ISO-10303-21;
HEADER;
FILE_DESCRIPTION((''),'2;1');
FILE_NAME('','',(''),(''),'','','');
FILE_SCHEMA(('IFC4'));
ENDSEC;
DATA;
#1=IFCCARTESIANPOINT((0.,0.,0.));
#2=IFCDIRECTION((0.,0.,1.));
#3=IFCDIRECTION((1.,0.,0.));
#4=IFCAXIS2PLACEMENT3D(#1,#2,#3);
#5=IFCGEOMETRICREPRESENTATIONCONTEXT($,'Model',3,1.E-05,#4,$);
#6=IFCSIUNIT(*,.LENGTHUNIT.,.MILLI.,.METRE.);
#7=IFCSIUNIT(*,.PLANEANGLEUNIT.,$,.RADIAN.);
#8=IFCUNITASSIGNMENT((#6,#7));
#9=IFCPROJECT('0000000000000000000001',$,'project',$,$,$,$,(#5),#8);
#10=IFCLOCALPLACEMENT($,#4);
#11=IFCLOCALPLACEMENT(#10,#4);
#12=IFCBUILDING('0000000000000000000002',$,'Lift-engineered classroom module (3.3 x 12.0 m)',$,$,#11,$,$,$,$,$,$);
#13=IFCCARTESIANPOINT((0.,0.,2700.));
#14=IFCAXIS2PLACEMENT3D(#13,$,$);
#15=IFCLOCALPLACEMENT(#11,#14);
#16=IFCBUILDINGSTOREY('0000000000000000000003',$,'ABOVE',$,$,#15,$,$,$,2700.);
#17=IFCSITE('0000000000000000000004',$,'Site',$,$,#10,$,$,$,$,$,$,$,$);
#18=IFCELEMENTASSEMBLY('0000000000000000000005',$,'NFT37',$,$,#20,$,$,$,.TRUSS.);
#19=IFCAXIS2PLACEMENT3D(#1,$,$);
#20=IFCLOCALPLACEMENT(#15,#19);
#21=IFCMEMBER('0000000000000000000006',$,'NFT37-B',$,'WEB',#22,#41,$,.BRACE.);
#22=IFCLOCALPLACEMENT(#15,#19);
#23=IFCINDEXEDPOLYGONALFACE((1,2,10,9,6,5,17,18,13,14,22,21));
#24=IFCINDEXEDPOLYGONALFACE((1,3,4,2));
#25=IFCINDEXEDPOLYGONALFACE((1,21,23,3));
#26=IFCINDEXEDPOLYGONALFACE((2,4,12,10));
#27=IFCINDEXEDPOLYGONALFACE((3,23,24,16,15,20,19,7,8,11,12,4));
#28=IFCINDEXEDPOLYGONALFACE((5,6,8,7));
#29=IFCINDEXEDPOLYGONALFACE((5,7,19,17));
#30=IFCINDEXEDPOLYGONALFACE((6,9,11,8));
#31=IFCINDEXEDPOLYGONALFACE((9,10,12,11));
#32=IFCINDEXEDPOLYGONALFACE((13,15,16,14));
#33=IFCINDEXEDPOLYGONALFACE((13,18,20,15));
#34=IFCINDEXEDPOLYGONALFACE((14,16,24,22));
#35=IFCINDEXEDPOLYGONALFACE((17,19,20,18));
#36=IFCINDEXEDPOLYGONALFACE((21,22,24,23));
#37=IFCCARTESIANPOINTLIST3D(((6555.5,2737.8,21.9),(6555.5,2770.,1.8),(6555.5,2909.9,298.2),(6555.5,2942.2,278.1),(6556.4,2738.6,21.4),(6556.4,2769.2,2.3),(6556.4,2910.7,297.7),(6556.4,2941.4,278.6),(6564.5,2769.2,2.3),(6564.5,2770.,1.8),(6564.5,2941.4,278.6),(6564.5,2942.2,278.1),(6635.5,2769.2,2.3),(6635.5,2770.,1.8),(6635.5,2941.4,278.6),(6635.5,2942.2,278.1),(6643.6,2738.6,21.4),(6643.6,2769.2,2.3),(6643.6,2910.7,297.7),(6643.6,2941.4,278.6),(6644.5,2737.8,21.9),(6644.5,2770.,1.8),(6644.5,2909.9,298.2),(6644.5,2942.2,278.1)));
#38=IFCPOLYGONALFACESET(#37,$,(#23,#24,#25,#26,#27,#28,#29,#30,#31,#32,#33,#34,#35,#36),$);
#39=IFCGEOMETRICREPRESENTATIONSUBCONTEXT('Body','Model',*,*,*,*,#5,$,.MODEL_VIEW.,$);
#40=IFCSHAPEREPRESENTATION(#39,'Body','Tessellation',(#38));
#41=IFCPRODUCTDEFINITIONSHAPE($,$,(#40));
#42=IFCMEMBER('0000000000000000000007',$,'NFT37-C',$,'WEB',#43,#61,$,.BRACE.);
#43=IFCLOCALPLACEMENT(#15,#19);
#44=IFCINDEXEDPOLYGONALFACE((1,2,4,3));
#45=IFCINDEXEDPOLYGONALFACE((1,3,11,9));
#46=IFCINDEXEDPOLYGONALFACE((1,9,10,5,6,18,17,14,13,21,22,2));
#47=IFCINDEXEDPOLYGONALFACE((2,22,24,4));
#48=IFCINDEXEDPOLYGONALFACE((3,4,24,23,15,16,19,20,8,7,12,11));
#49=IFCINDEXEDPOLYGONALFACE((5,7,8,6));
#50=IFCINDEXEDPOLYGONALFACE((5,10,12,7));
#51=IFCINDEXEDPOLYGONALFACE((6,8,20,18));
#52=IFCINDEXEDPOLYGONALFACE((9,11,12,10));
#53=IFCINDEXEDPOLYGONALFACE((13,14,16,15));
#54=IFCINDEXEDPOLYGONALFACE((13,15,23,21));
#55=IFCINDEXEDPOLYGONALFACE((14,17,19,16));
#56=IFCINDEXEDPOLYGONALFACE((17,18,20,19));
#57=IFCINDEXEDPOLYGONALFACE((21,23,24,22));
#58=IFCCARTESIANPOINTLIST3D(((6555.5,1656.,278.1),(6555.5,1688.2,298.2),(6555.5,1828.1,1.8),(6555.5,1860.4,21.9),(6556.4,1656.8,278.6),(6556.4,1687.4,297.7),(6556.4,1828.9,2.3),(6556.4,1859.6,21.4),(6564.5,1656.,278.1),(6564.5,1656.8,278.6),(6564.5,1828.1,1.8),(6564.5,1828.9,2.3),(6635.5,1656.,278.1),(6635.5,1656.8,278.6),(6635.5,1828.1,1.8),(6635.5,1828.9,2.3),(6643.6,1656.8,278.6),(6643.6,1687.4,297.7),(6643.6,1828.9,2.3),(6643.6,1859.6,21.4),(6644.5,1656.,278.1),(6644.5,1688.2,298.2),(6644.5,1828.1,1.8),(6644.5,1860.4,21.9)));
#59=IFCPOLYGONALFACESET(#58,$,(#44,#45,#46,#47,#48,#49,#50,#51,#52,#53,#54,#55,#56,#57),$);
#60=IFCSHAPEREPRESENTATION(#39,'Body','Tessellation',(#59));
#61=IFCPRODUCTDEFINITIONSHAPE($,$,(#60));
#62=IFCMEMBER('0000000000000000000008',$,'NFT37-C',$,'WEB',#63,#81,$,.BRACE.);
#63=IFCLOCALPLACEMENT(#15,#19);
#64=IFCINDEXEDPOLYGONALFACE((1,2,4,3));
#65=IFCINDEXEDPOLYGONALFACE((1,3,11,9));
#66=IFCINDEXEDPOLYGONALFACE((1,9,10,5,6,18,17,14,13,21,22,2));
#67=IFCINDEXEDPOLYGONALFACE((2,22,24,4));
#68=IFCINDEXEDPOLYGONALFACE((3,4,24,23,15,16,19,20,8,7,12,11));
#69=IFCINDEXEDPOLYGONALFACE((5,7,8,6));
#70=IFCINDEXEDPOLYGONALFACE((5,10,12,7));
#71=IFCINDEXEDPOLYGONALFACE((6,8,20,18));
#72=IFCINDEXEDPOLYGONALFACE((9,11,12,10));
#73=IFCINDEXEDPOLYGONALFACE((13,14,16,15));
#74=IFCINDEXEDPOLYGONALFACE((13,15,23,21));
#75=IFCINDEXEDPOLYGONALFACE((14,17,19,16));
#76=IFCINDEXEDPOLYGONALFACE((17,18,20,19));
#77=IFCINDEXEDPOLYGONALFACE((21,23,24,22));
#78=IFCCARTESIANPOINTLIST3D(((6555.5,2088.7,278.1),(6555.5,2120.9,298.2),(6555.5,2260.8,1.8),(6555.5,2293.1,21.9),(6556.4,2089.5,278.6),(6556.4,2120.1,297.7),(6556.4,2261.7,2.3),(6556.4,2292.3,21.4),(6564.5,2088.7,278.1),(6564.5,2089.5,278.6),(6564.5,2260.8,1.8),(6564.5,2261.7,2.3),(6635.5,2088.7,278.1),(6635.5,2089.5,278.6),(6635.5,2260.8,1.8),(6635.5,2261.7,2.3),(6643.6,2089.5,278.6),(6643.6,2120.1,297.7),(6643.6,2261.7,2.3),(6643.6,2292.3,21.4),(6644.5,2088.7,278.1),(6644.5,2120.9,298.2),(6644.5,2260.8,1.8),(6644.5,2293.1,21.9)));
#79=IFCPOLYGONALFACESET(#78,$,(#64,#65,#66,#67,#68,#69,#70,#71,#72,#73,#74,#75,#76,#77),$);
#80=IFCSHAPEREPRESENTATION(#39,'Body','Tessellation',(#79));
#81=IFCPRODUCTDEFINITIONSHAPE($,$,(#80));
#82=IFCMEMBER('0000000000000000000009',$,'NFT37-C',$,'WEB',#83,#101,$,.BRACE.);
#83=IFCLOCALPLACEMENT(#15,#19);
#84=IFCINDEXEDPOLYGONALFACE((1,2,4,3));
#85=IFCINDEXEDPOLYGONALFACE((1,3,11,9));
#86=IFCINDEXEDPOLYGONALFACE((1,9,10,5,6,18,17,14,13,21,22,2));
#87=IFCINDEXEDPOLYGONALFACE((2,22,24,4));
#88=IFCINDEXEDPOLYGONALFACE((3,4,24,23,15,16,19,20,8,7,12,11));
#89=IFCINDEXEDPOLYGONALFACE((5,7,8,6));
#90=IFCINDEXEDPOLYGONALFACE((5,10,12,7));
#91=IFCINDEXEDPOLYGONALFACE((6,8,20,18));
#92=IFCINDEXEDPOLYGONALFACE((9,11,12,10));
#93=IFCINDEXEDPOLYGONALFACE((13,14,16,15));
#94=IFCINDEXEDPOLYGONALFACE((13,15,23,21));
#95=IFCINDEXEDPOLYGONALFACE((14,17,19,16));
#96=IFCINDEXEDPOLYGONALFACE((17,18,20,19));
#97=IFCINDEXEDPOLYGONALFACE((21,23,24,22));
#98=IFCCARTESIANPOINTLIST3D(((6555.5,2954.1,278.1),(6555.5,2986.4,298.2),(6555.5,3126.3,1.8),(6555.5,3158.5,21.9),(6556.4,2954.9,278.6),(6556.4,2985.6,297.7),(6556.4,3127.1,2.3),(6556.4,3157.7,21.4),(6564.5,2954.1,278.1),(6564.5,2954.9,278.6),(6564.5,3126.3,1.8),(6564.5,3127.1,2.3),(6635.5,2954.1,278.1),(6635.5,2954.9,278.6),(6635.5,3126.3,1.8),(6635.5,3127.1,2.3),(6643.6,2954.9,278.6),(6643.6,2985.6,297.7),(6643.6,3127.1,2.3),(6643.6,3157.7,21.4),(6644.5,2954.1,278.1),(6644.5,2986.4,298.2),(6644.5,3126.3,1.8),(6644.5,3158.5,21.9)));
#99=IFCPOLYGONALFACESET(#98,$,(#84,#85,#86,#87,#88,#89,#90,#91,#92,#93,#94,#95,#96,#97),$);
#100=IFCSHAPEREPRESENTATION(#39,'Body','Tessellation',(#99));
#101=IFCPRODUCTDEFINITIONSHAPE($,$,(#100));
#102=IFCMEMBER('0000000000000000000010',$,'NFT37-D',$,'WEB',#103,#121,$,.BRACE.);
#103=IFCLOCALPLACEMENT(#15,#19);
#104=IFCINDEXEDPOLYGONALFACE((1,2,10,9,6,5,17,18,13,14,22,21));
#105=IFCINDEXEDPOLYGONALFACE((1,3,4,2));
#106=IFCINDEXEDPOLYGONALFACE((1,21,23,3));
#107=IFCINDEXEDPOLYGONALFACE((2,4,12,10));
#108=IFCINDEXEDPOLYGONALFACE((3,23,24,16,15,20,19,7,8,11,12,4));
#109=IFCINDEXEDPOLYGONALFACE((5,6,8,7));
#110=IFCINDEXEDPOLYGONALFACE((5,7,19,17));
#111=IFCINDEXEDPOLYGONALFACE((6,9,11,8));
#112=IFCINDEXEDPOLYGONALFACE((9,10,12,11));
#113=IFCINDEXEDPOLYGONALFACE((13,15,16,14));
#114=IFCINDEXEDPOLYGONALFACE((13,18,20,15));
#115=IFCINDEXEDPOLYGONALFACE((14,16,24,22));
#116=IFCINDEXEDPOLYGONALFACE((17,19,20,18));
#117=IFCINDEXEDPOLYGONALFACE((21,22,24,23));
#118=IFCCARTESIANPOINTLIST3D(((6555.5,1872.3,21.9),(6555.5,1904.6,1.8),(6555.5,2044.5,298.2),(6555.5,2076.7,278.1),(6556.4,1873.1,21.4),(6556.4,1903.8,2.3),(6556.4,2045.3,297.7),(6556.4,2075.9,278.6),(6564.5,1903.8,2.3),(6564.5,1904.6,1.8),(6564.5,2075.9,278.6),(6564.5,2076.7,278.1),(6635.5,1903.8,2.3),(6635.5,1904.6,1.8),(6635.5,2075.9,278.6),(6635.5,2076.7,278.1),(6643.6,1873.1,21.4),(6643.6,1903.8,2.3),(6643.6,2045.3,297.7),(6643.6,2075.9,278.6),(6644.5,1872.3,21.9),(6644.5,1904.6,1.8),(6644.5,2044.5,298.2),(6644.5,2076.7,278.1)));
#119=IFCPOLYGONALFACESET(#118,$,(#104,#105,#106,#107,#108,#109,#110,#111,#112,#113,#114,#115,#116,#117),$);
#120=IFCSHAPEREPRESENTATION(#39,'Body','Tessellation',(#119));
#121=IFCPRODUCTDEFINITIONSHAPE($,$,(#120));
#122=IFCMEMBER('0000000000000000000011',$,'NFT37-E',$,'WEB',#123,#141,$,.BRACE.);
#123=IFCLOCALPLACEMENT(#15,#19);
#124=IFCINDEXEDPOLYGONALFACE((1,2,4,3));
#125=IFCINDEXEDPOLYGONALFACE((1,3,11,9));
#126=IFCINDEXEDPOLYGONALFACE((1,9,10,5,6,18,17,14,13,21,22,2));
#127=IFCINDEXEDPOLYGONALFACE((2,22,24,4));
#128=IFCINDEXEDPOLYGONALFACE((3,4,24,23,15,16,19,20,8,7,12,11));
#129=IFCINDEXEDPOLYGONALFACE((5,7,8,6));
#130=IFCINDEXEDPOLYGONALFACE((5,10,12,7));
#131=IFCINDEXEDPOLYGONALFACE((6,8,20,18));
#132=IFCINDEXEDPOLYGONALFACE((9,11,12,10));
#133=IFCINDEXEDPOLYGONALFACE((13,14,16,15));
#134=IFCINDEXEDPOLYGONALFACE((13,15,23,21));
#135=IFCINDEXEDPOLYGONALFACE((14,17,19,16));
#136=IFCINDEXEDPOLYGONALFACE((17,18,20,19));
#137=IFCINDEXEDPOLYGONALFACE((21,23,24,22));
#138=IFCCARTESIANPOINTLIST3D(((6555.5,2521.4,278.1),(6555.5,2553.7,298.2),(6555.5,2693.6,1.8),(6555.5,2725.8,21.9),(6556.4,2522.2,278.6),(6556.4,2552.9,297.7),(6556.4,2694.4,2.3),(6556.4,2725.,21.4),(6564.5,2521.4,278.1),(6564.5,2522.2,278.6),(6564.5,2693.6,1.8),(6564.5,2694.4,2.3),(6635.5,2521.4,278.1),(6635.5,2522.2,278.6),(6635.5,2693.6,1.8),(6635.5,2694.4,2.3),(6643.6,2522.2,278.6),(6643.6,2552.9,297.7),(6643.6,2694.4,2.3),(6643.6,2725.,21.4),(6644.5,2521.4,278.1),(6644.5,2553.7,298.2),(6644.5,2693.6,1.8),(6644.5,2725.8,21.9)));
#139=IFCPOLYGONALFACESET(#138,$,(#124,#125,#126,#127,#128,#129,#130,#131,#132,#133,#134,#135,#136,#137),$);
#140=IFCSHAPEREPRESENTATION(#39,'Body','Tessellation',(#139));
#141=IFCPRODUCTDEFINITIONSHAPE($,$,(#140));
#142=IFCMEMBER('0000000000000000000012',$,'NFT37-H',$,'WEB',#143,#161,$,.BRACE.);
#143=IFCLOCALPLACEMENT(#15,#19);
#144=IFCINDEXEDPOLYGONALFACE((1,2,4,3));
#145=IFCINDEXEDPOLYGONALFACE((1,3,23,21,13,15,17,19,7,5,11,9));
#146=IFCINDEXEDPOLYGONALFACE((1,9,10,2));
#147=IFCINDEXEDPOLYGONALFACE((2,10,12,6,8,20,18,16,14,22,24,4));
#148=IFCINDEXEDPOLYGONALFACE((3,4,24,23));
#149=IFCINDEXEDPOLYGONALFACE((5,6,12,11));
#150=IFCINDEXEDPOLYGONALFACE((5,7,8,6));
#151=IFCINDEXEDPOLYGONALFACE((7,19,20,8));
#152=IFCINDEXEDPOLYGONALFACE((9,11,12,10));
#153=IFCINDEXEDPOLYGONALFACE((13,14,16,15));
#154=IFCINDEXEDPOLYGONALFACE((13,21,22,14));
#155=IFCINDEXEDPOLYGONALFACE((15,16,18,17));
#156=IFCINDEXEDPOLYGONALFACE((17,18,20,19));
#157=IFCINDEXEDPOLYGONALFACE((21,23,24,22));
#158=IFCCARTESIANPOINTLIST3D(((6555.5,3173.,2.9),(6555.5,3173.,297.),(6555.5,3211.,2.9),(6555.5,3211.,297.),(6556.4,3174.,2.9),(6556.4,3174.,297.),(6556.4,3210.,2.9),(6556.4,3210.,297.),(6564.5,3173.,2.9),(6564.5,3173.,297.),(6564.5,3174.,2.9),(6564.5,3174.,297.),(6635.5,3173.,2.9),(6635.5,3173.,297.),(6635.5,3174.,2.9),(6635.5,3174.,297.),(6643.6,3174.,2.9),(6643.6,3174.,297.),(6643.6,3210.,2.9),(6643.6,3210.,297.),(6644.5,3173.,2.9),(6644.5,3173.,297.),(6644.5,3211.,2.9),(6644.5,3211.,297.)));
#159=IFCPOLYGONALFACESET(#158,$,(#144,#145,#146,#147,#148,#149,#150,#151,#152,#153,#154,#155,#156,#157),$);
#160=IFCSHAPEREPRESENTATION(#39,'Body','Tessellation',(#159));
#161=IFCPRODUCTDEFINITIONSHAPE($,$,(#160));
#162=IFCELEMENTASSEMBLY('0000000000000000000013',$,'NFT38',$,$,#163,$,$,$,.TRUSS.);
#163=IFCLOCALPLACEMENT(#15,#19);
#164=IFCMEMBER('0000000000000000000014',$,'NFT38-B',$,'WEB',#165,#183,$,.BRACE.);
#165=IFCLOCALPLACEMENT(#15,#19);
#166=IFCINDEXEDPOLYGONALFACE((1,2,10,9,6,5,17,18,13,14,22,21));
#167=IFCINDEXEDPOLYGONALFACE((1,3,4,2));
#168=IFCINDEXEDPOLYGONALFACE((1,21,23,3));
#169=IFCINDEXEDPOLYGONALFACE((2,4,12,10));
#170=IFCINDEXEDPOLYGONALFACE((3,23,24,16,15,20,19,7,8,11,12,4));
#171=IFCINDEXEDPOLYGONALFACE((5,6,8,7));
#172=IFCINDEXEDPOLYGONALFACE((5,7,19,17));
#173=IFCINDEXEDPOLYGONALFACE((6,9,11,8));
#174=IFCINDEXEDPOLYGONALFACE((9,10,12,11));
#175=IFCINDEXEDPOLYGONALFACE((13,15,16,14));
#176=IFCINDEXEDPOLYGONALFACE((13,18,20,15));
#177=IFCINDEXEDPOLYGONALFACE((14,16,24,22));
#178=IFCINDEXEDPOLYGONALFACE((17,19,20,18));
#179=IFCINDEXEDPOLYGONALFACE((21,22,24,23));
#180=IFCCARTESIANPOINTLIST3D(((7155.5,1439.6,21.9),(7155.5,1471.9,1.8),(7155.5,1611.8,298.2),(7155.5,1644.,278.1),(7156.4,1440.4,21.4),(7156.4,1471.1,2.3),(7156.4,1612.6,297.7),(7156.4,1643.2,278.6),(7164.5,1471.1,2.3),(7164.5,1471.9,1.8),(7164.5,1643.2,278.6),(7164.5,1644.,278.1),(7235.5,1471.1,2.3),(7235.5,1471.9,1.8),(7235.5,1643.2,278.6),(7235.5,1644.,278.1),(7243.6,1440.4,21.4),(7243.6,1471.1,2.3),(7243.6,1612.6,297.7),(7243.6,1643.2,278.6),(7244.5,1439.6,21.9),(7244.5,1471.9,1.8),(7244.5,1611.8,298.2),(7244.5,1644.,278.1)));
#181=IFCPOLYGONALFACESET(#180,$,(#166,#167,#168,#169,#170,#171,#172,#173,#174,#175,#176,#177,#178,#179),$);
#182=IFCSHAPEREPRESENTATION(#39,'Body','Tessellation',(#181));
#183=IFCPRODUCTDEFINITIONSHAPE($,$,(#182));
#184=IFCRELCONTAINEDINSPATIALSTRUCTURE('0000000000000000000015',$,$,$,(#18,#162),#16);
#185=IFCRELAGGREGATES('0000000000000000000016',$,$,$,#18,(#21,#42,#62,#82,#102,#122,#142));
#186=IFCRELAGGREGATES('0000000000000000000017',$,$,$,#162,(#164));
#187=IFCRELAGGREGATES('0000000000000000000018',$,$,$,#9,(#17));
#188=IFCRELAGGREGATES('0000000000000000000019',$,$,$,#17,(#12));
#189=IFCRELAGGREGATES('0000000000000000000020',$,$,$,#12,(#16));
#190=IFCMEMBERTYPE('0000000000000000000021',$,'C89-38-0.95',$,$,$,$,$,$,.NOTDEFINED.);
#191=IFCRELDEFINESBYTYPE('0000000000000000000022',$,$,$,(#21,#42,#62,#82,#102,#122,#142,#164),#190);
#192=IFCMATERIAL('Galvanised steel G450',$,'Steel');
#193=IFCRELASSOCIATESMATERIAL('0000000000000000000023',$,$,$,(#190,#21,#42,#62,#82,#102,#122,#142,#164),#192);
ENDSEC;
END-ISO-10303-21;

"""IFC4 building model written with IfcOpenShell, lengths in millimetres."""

from ifc_helpers import new_model, si_unit, frame, origin, origin_with_axes, origin_2d, place, context, subcontext, project, spatial, c_section, extrude, material, material_profile, profile_set, profile_usage, type_object, element, aggregate, save


model = new_model("IFC4")

# Units and contexts
model_context = context("Model", 3, precision=1e-05, world=origin_with_axes())
body_context = subcontext(model_context, "Body", "Model", "MODEL_VIEW")
ifc_project = project(units=[si_unit("LENGTHUNIT", "METRE", prefix="MILLI"), si_unit("PLANEANGLEUNIT", "RADIAN")], contexts=[model_context])

# Site, building, storey
site_placement = place(None, origin_with_axes())
site = spatial("IfcSite", under=ifc_project, at=site_placement, Name="Site")
building_placement = place(site_placement, origin_with_axes())
building = spatial("IfcBuilding", under=site, at=building_placement, Name="Lift-engineered classroom module (3.3 x 12.0 m)")
storey_placement = place(building_placement, frame((0.0, 0.0, 2700.0)))
storey = spatial("IfcBuildingStorey", under=building, at=storey_placement, Name="ABOVE", Elevation=2700.0)

# Element assemblies, members
ifc_material = material(Name="Galvanised steel G450", Category="Steel")
ifc_material_profile_1 = material_profile(ifc_material, c_section(Depth=89.0, Width=38.0, WallThickness=0.9, Girth=9.0, at=origin_2d()), Name="C89-38-0.95")
ifc_profile_set_1 = profile_set([ifc_material_profile_1], Name="C89-38-0.95")
ifc_profile_usage_1 = profile_usage(ifc_profile_set_1)
member_type_1 = type_object("IfcMemberType", Name="C89-38-0.95", PredefinedType="NOTDEFINED", material=ifc_profile_set_1)
assembly_1_placement = place(storey_placement, frame((6600.0, 89.0, 0.0)))
assembly_1 = element("IfcElementAssembly", 1, at=assembly_1_placement, inside=storey, Name="NFT37", PredefinedType="TRUSS")
member_1_placement = place(assembly_1_placement, frame((0.0, 2664.9, 11.8), z_axis=(0.0, 0.528797, 0.848748), x_axis=(0.0, 0.848748, -0.528797)))
member_1 = element("IfcMember", 2, at=member_1_placement, type_object=member_type_1, material=ifc_profile_usage_1, Name="NFT37-B", ObjectType="WEB", PredefinedType="BRACE", context=body_context, shape_type="SweptSolid", body=[
    extrude(c_section(Depth=89.0, Width=38.0, WallThickness=0.9, Girth=9.0, at=origin_2d()), origin(), (0.0, 0.0, 1.0), 325.6),
])
member_2_placement = place(assembly_1_placement, frame((0.0, 1755.3, 11.8), z_axis=(0.0, -0.528797, 0.848748), x_axis=(0.0, -0.848748, -0.528797)))
member_2 = element("IfcMember", 3, at=member_2_placement, type_object=member_type_1, material=ifc_profile_usage_1, Name="NFT37-C", ObjectType="WEB", PredefinedType="BRACE", context=body_context, shape_type="SweptSolid", body=[
    extrude(c_section(Depth=89.0, Width=38.0, WallThickness=0.9, Girth=9.0, at=origin_2d()), origin(), (0.0, 0.0, 1.0), 325.6),
])
member_3_placement = place(assembly_1_placement, frame((0.0, 2188.0, 11.8), z_axis=(0.0, -0.528797, 0.848748), x_axis=(0.0, -0.848748, -0.528797)))
member_3 = element("IfcMember", 4, at=member_3_placement, type_object=member_type_1, material=ifc_profile_usage_1, Name="NFT37-C", ObjectType="WEB", PredefinedType="BRACE", context=body_context, shape_type="SweptSolid", body=[
    extrude(c_section(Depth=89.0, Width=38.0, WallThickness=0.9, Girth=9.0, at=origin_2d()), origin(), (0.0, 0.0, 1.0), 325.6),
])
member_4_placement = place(assembly_1_placement, frame((0.0, 3053.4, 11.8), z_axis=(0.0, -0.528797, 0.848748), x_axis=(0.0, -0.848748, -0.528797)))
member_4 = element("IfcMember", 5, at=member_4_placement, type_object=member_type_1, material=ifc_profile_usage_1, Name="NFT37-C", ObjectType="WEB", PredefinedType="BRACE", context=body_context, shape_type="SweptSolid", body=[
    extrude(c_section(Depth=89.0, Width=38.0, WallThickness=0.9, Girth=9.0, at=origin_2d()), origin(), (0.0, 0.0, 1.0), 325.6),
])
member_5_placement = place(assembly_1_placement, frame((0.0, 1799.5, 11.8), z_axis=(0.0, 0.528775, 0.848762), x_axis=(0.0, 0.848762, -0.528775)))
member_5 = element("IfcMember", 6, at=member_5_placement, type_object=member_type_1, material=ifc_profile_usage_1, Name="NFT37-D", ObjectType="WEB", PredefinedType="BRACE", context=body_context, shape_type="SweptSolid", body=[
    extrude(c_section(Depth=89.0, Width=38.0, WallThickness=0.9, Girth=9.0, at=origin_2d()), origin(), (0.0, 0.0, 1.0), 325.6),
])
member_6_placement = place(assembly_1_placement, frame((0.0, 2620.7, 11.8), z_axis=(0.0, -0.528775, 0.848762), x_axis=(0.0, -0.848762, -0.528775)))
member_6 = element("IfcMember", 7, at=member_6_placement, type_object=member_type_1, material=ifc_profile_usage_1, Name="NFT37-E", ObjectType="WEB", PredefinedType="BRACE", context=body_context, shape_type="SweptSolid", body=[
    extrude(c_section(Depth=89.0, Width=38.0, WallThickness=0.9, Girth=9.0, at=origin_2d()), origin(), (0.0, 0.0, 1.0), 325.6),
])
member_7_placement = place(assembly_1_placement, frame((0.0, 3103.0, 2.9), z_axis=(0.0, 0.0, 1.0), x_axis=(0.0, -1.0, 0.0)))
member_7 = element("IfcMember", 8, at=member_7_placement, type_object=member_type_1, material=ifc_profile_usage_1, Name="NFT37-H", ObjectType="WEB", PredefinedType="BRACE", context=body_context, shape_type="SweptSolid", body=[
    extrude(c_section(Depth=89.0, Width=38.0, WallThickness=0.9, Girth=9.0, at=origin_2d()), origin(), (0.0, 0.0, 1.0), 294.1),
])
aggregate(assembly_1, [member_1, member_2, member_3, member_4, member_5, member_6, member_7])
assembly_2_placement = place(storey_placement, frame((7200.0, 89.0, 0.0)))
assembly_2 = element("IfcElementAssembly", 9, at=assembly_2_placement, inside=storey, Name="NFT38", PredefinedType="TRUSS")
member_8_placement = place(assembly_2_placement, frame((0.0, 1366.7, 11.8), z_axis=(0.0, 0.528797, 0.848748), x_axis=(0.0, 0.848748, -0.528797)))
member_8 = element("IfcMember", 10, at=member_8_placement, type_object=member_type_1, material=ifc_profile_usage_1, Name="NFT38-B", ObjectType="WEB", PredefinedType="BRACE", context=body_context, shape_type="SweptSolid", body=[
    extrude(c_section(Depth=89.0, Width=38.0, WallThickness=0.9, Girth=9.0, at=origin_2d()), origin(), (0.0, 0.0, 1.0), 325.6),
])
aggregate(assembly_2, [member_8])

save(model, "model.ifc")
